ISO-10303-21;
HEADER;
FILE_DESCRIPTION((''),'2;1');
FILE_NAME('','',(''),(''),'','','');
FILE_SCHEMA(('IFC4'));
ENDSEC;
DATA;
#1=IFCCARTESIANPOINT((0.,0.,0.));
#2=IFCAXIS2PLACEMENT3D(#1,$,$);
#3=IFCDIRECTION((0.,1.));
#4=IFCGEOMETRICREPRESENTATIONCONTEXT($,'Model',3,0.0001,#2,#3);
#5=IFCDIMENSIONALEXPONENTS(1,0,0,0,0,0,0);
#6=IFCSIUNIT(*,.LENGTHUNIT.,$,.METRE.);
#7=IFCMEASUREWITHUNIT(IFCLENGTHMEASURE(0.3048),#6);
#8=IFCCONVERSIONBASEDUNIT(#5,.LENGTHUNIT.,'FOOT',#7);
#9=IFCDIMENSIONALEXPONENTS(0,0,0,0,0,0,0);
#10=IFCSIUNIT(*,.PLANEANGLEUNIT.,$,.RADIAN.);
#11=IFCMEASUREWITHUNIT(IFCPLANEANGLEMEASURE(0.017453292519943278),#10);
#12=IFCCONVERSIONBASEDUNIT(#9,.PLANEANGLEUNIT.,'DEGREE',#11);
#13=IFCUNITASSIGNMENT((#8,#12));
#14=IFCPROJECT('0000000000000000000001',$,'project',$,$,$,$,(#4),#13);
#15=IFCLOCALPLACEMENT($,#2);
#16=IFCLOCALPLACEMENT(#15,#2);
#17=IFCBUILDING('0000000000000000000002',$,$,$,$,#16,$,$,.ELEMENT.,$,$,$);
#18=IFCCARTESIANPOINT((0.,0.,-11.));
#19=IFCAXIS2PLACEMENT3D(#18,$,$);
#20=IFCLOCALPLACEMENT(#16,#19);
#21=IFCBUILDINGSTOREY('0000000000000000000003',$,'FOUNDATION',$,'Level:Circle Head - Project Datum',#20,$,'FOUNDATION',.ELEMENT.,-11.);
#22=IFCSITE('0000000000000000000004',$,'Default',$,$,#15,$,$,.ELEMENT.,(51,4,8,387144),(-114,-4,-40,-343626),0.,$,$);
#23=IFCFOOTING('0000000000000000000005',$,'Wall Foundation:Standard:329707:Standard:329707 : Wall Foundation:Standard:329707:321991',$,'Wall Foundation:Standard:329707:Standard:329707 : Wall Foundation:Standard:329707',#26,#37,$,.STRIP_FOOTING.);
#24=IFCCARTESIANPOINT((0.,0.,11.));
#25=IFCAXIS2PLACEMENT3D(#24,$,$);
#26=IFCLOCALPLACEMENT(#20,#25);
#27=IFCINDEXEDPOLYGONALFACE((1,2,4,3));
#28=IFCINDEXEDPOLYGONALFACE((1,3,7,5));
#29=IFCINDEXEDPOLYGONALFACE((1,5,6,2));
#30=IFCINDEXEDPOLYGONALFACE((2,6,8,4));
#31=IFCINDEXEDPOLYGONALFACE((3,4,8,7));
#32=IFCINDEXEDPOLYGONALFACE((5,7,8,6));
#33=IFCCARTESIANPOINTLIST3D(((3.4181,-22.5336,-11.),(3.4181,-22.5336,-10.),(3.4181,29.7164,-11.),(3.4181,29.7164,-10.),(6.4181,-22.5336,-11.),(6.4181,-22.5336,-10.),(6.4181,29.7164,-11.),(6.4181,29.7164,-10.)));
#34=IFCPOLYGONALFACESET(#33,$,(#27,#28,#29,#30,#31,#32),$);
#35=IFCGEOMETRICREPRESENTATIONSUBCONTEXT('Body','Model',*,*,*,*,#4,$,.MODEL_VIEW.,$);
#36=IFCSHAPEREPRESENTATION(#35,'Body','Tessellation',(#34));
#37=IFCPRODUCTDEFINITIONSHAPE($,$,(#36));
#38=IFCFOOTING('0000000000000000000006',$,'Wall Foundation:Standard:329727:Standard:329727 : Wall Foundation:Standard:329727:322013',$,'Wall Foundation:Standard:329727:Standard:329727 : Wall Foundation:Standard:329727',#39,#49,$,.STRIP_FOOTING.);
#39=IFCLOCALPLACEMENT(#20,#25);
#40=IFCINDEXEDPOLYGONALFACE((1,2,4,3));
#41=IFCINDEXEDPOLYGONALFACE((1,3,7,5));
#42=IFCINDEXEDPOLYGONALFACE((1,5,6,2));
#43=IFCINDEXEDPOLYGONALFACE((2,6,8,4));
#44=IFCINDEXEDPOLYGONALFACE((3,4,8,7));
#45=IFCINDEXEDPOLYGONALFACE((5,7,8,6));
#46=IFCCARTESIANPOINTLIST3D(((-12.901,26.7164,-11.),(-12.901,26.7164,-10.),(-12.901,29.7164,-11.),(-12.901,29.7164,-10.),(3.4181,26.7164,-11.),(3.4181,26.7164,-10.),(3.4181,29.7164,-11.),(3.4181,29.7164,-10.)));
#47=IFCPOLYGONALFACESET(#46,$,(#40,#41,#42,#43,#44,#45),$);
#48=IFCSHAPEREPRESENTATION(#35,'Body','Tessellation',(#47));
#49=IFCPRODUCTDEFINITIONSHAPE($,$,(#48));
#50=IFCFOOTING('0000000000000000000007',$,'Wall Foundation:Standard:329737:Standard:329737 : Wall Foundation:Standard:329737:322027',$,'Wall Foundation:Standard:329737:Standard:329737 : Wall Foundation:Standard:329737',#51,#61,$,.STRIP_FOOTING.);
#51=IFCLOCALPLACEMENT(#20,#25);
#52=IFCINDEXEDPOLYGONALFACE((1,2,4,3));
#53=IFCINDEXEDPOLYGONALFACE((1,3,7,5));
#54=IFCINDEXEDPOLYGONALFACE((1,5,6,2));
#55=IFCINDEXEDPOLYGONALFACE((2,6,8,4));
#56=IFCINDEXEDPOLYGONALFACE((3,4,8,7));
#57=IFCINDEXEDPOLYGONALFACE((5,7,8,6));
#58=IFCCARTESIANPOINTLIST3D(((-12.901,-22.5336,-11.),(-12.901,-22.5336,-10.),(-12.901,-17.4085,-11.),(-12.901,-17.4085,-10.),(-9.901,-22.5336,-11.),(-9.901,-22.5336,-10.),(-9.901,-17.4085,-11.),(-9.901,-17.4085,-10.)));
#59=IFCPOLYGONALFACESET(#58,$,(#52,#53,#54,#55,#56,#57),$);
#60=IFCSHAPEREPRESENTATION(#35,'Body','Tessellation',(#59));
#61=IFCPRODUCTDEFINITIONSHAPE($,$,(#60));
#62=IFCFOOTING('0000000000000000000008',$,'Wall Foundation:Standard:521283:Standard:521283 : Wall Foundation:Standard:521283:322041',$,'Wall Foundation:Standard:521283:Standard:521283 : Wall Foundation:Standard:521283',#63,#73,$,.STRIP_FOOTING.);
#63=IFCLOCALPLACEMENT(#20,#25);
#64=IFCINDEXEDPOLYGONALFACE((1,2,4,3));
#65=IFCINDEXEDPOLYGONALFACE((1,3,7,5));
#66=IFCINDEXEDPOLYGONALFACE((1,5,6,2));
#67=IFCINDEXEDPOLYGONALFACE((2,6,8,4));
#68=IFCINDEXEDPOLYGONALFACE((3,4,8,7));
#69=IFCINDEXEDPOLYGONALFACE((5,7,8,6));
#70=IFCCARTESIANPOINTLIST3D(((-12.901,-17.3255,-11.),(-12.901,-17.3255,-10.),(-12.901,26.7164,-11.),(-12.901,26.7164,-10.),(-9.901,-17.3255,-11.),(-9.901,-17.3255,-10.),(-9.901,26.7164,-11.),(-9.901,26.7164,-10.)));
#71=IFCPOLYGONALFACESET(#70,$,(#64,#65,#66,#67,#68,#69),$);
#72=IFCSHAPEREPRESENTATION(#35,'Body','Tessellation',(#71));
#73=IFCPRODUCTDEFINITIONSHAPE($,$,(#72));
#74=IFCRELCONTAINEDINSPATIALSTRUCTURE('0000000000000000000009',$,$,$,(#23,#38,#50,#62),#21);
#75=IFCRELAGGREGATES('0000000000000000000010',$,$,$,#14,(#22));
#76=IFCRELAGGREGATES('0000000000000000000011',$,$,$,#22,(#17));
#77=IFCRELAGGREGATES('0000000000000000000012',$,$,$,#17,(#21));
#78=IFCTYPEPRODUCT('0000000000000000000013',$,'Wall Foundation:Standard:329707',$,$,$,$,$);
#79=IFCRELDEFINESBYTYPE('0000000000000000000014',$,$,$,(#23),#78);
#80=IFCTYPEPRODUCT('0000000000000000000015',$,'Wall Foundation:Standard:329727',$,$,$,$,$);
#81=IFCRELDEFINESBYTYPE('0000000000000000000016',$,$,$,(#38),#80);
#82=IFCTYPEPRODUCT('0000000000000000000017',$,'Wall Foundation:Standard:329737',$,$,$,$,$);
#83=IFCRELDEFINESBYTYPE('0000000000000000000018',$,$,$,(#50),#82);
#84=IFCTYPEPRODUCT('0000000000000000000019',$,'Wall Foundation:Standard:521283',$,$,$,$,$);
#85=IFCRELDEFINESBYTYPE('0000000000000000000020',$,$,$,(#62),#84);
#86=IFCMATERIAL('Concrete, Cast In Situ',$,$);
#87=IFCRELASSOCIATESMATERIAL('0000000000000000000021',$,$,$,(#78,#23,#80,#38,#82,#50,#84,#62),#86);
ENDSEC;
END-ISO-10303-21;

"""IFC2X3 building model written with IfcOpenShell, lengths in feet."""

from ifc_helpers import new_model, entity, si_unit, converted_unit, direction, frame, frame_2d, origin, origin_2d_with_axis, place, context, subcontext, project, spatial, rectangle, extrude, source, transform, mapped, material, type_object, type_shapes, element, save


model = new_model("IFC2X3")

# Units and contexts
model_context = context("Model", 3, precision=0.0001, world=origin(), true_north=direction((0.0, 1.0)))
body_context = subcontext(model_context, "Body", "Model", "MODEL_VIEW")
ifc_project = project(units=[converted_unit("LENGTHUNIT", "FOOT", entity("IfcLengthMeasure", 0.3048), si_unit("LENGTHUNIT", "METRE"), dimensions=[1, 0, 0, 0, 0, 0, 0]), converted_unit("PLANEANGLEUNIT", "DEGREE", entity("IfcPlaneAngleMeasure", 0.017453292519943278), si_unit("PLANEANGLEUNIT", "RADIAN"), dimensions=[0, 0, 0, 0, 0, 0, 0])], contexts=[model_context])

# Site, building, storey
site_placement = place(None, origin())
site = spatial("IfcSite", under=ifc_project, at=site_placement, Name="Default", CompositionType="ELEMENT", RefLatitude=(51, 4, 8, 387144), RefLongitude=(-114, -4, -40, -343626), RefElevation=0.0)
building_placement = place(site_placement, origin())
building = spatial("IfcBuilding", under=site, at=building_placement, CompositionType="ELEMENT")
storey_placement = place(building_placement, frame((0.0, 0.0, -11.0)))
storey = spatial("IfcBuildingStorey", under=building, at=storey_placement, Name="FOUNDATION", ObjectType="Level:Circle Head - Project Datum", LongName="FOUNDATION", CompositionType="ELEMENT", Elevation=-11.0)

# Footings
ifc_material = material(Name="Concrete, Cast In Situ")
type_product_1 = type_object("IfcTypeProduct", Name="Wall Foundation:Standard:329707", material=ifc_material)
shared_shape_1 = source(origin(), body_context, "Body", "SweptSolid", [
    extrude(rectangle(XDim=3.0, YDim=52.25, at=frame_2d((0.0, 0.0), x_axis=(1.0, 0.0))), frame((4.9181, 3.5914, -11.0)), (0.0, 0.0, 1.0), 1.0),
])
type_shapes(type_product_1, [shared_shape_1])
footing_1_placement = place(storey_placement, frame((0.0, 0.0, 11.0)))
element("IfcFooting", 1, at=footing_1_placement, inside=storey, type_object=type_product_1, material=ifc_material, Name="Wall Foundation:Standard:329707:Standard:329707 : Wall Foundation:Standard:329707:321991", ObjectType="Wall Foundation:Standard:329707:Standard:329707 : Wall Foundation:Standard:329707", PredefinedType="STRIP_FOOTING", context=body_context, shape_type="MappedRepresentation", body=[
    mapped(shared_shape_1, transform((0.0, 0.0, 0.0), scale=1.0)),
])
type_product_2 = type_object("IfcTypeProduct", Name="Wall Foundation:Standard:329727", material=ifc_material)
shared_shape_2 = source(origin(), body_context, "Body", "SweptSolid", [
    extrude(rectangle(XDim=3.0, YDim=16.3192, at=origin_2d_with_axis()), frame((-4.7415, 28.2164, -11.0), z_axis=(0.0, 0.0, 1.0), x_axis=(0.0, 1.0, 0.0)), (0.0, 0.0, 1.0), 1.0),
])
type_shapes(type_product_2, [shared_shape_2])
footing_2_placement = place(storey_placement, frame((0.0, 0.0, 11.0)))
element("IfcFooting", 2, at=footing_2_placement, inside=storey, type_object=type_product_2, material=ifc_material, Name="Wall Foundation:Standard:329727:Standard:329727 : Wall Foundation:Standard:329727:322013", ObjectType="Wall Foundation:Standard:329727:Standard:329727 : Wall Foundation:Standard:329727", PredefinedType="STRIP_FOOTING", context=body_context, shape_type="MappedRepresentation", body=[
    mapped(shared_shape_2, transform((0.0, 0.0, 0.0), scale=1.0)),
])
type_product_3 = type_object("IfcTypeProduct", Name="Wall Foundation:Standard:329737", material=ifc_material)
shared_shape_3 = source(origin(), body_context, "Body", "SweptSolid", [
    extrude(rectangle(XDim=3.0, YDim=5.1252, at=origin_2d_with_axis()), frame((-11.401, -19.971, -11.0), z_axis=(0.0, 0.0, 1.0), x_axis=(-1.0, 0.0, 0.0)), (0.0, 0.0, 1.0), 1.0),
])
type_shapes(type_product_3, [shared_shape_3])
footing_3_placement = place(storey_placement, frame((0.0, 0.0, 11.0)))
element("IfcFooting", 3, at=footing_3_placement, inside=storey, type_object=type_product_3, material=ifc_material, Name="Wall Foundation:Standard:329737:Standard:329737 : Wall Foundation:Standard:329737:322027", ObjectType="Wall Foundation:Standard:329737:Standard:329737 : Wall Foundation:Standard:329737", PredefinedType="STRIP_FOOTING", context=body_context, shape_type="MappedRepresentation", body=[
    mapped(shared_shape_3, transform((0.0, 0.0, 0.0), scale=1.0)),
])
type_product_4 = type_object("IfcTypeProduct", Name="Wall Foundation:Standard:521283", material=ifc_material)
shared_shape_4 = source(origin(), body_context, "Body", "SweptSolid", [
    extrude(rectangle(XDim=3.0, YDim=44.0418, at=origin_2d_with_axis()), frame((-11.401, 4.6955, -11.0), z_axis=(0.0, 0.0, 1.0), x_axis=(-1.0, 0.0, 0.0)), (0.0, 0.0, 1.0), 1.0),
])
type_shapes(type_product_4, [shared_shape_4])
footing_4_placement = place(storey_placement, frame((0.0, 0.0, 11.0)))
element("IfcFooting", 4, at=footing_4_placement, inside=storey, type_object=type_product_4, material=ifc_material, Name="Wall Foundation:Standard:521283:Standard:521283 : Wall Foundation:Standard:521283:322041", ObjectType="Wall Foundation:Standard:521283:Standard:521283 : Wall Foundation:Standard:521283", PredefinedType="STRIP_FOOTING", context=body_context, shape_type="MappedRepresentation", body=[
    mapped(shared_shape_4, transform((0.0, 0.0, 0.0), scale=1.0)),
])

save(model, "model.ifc")
